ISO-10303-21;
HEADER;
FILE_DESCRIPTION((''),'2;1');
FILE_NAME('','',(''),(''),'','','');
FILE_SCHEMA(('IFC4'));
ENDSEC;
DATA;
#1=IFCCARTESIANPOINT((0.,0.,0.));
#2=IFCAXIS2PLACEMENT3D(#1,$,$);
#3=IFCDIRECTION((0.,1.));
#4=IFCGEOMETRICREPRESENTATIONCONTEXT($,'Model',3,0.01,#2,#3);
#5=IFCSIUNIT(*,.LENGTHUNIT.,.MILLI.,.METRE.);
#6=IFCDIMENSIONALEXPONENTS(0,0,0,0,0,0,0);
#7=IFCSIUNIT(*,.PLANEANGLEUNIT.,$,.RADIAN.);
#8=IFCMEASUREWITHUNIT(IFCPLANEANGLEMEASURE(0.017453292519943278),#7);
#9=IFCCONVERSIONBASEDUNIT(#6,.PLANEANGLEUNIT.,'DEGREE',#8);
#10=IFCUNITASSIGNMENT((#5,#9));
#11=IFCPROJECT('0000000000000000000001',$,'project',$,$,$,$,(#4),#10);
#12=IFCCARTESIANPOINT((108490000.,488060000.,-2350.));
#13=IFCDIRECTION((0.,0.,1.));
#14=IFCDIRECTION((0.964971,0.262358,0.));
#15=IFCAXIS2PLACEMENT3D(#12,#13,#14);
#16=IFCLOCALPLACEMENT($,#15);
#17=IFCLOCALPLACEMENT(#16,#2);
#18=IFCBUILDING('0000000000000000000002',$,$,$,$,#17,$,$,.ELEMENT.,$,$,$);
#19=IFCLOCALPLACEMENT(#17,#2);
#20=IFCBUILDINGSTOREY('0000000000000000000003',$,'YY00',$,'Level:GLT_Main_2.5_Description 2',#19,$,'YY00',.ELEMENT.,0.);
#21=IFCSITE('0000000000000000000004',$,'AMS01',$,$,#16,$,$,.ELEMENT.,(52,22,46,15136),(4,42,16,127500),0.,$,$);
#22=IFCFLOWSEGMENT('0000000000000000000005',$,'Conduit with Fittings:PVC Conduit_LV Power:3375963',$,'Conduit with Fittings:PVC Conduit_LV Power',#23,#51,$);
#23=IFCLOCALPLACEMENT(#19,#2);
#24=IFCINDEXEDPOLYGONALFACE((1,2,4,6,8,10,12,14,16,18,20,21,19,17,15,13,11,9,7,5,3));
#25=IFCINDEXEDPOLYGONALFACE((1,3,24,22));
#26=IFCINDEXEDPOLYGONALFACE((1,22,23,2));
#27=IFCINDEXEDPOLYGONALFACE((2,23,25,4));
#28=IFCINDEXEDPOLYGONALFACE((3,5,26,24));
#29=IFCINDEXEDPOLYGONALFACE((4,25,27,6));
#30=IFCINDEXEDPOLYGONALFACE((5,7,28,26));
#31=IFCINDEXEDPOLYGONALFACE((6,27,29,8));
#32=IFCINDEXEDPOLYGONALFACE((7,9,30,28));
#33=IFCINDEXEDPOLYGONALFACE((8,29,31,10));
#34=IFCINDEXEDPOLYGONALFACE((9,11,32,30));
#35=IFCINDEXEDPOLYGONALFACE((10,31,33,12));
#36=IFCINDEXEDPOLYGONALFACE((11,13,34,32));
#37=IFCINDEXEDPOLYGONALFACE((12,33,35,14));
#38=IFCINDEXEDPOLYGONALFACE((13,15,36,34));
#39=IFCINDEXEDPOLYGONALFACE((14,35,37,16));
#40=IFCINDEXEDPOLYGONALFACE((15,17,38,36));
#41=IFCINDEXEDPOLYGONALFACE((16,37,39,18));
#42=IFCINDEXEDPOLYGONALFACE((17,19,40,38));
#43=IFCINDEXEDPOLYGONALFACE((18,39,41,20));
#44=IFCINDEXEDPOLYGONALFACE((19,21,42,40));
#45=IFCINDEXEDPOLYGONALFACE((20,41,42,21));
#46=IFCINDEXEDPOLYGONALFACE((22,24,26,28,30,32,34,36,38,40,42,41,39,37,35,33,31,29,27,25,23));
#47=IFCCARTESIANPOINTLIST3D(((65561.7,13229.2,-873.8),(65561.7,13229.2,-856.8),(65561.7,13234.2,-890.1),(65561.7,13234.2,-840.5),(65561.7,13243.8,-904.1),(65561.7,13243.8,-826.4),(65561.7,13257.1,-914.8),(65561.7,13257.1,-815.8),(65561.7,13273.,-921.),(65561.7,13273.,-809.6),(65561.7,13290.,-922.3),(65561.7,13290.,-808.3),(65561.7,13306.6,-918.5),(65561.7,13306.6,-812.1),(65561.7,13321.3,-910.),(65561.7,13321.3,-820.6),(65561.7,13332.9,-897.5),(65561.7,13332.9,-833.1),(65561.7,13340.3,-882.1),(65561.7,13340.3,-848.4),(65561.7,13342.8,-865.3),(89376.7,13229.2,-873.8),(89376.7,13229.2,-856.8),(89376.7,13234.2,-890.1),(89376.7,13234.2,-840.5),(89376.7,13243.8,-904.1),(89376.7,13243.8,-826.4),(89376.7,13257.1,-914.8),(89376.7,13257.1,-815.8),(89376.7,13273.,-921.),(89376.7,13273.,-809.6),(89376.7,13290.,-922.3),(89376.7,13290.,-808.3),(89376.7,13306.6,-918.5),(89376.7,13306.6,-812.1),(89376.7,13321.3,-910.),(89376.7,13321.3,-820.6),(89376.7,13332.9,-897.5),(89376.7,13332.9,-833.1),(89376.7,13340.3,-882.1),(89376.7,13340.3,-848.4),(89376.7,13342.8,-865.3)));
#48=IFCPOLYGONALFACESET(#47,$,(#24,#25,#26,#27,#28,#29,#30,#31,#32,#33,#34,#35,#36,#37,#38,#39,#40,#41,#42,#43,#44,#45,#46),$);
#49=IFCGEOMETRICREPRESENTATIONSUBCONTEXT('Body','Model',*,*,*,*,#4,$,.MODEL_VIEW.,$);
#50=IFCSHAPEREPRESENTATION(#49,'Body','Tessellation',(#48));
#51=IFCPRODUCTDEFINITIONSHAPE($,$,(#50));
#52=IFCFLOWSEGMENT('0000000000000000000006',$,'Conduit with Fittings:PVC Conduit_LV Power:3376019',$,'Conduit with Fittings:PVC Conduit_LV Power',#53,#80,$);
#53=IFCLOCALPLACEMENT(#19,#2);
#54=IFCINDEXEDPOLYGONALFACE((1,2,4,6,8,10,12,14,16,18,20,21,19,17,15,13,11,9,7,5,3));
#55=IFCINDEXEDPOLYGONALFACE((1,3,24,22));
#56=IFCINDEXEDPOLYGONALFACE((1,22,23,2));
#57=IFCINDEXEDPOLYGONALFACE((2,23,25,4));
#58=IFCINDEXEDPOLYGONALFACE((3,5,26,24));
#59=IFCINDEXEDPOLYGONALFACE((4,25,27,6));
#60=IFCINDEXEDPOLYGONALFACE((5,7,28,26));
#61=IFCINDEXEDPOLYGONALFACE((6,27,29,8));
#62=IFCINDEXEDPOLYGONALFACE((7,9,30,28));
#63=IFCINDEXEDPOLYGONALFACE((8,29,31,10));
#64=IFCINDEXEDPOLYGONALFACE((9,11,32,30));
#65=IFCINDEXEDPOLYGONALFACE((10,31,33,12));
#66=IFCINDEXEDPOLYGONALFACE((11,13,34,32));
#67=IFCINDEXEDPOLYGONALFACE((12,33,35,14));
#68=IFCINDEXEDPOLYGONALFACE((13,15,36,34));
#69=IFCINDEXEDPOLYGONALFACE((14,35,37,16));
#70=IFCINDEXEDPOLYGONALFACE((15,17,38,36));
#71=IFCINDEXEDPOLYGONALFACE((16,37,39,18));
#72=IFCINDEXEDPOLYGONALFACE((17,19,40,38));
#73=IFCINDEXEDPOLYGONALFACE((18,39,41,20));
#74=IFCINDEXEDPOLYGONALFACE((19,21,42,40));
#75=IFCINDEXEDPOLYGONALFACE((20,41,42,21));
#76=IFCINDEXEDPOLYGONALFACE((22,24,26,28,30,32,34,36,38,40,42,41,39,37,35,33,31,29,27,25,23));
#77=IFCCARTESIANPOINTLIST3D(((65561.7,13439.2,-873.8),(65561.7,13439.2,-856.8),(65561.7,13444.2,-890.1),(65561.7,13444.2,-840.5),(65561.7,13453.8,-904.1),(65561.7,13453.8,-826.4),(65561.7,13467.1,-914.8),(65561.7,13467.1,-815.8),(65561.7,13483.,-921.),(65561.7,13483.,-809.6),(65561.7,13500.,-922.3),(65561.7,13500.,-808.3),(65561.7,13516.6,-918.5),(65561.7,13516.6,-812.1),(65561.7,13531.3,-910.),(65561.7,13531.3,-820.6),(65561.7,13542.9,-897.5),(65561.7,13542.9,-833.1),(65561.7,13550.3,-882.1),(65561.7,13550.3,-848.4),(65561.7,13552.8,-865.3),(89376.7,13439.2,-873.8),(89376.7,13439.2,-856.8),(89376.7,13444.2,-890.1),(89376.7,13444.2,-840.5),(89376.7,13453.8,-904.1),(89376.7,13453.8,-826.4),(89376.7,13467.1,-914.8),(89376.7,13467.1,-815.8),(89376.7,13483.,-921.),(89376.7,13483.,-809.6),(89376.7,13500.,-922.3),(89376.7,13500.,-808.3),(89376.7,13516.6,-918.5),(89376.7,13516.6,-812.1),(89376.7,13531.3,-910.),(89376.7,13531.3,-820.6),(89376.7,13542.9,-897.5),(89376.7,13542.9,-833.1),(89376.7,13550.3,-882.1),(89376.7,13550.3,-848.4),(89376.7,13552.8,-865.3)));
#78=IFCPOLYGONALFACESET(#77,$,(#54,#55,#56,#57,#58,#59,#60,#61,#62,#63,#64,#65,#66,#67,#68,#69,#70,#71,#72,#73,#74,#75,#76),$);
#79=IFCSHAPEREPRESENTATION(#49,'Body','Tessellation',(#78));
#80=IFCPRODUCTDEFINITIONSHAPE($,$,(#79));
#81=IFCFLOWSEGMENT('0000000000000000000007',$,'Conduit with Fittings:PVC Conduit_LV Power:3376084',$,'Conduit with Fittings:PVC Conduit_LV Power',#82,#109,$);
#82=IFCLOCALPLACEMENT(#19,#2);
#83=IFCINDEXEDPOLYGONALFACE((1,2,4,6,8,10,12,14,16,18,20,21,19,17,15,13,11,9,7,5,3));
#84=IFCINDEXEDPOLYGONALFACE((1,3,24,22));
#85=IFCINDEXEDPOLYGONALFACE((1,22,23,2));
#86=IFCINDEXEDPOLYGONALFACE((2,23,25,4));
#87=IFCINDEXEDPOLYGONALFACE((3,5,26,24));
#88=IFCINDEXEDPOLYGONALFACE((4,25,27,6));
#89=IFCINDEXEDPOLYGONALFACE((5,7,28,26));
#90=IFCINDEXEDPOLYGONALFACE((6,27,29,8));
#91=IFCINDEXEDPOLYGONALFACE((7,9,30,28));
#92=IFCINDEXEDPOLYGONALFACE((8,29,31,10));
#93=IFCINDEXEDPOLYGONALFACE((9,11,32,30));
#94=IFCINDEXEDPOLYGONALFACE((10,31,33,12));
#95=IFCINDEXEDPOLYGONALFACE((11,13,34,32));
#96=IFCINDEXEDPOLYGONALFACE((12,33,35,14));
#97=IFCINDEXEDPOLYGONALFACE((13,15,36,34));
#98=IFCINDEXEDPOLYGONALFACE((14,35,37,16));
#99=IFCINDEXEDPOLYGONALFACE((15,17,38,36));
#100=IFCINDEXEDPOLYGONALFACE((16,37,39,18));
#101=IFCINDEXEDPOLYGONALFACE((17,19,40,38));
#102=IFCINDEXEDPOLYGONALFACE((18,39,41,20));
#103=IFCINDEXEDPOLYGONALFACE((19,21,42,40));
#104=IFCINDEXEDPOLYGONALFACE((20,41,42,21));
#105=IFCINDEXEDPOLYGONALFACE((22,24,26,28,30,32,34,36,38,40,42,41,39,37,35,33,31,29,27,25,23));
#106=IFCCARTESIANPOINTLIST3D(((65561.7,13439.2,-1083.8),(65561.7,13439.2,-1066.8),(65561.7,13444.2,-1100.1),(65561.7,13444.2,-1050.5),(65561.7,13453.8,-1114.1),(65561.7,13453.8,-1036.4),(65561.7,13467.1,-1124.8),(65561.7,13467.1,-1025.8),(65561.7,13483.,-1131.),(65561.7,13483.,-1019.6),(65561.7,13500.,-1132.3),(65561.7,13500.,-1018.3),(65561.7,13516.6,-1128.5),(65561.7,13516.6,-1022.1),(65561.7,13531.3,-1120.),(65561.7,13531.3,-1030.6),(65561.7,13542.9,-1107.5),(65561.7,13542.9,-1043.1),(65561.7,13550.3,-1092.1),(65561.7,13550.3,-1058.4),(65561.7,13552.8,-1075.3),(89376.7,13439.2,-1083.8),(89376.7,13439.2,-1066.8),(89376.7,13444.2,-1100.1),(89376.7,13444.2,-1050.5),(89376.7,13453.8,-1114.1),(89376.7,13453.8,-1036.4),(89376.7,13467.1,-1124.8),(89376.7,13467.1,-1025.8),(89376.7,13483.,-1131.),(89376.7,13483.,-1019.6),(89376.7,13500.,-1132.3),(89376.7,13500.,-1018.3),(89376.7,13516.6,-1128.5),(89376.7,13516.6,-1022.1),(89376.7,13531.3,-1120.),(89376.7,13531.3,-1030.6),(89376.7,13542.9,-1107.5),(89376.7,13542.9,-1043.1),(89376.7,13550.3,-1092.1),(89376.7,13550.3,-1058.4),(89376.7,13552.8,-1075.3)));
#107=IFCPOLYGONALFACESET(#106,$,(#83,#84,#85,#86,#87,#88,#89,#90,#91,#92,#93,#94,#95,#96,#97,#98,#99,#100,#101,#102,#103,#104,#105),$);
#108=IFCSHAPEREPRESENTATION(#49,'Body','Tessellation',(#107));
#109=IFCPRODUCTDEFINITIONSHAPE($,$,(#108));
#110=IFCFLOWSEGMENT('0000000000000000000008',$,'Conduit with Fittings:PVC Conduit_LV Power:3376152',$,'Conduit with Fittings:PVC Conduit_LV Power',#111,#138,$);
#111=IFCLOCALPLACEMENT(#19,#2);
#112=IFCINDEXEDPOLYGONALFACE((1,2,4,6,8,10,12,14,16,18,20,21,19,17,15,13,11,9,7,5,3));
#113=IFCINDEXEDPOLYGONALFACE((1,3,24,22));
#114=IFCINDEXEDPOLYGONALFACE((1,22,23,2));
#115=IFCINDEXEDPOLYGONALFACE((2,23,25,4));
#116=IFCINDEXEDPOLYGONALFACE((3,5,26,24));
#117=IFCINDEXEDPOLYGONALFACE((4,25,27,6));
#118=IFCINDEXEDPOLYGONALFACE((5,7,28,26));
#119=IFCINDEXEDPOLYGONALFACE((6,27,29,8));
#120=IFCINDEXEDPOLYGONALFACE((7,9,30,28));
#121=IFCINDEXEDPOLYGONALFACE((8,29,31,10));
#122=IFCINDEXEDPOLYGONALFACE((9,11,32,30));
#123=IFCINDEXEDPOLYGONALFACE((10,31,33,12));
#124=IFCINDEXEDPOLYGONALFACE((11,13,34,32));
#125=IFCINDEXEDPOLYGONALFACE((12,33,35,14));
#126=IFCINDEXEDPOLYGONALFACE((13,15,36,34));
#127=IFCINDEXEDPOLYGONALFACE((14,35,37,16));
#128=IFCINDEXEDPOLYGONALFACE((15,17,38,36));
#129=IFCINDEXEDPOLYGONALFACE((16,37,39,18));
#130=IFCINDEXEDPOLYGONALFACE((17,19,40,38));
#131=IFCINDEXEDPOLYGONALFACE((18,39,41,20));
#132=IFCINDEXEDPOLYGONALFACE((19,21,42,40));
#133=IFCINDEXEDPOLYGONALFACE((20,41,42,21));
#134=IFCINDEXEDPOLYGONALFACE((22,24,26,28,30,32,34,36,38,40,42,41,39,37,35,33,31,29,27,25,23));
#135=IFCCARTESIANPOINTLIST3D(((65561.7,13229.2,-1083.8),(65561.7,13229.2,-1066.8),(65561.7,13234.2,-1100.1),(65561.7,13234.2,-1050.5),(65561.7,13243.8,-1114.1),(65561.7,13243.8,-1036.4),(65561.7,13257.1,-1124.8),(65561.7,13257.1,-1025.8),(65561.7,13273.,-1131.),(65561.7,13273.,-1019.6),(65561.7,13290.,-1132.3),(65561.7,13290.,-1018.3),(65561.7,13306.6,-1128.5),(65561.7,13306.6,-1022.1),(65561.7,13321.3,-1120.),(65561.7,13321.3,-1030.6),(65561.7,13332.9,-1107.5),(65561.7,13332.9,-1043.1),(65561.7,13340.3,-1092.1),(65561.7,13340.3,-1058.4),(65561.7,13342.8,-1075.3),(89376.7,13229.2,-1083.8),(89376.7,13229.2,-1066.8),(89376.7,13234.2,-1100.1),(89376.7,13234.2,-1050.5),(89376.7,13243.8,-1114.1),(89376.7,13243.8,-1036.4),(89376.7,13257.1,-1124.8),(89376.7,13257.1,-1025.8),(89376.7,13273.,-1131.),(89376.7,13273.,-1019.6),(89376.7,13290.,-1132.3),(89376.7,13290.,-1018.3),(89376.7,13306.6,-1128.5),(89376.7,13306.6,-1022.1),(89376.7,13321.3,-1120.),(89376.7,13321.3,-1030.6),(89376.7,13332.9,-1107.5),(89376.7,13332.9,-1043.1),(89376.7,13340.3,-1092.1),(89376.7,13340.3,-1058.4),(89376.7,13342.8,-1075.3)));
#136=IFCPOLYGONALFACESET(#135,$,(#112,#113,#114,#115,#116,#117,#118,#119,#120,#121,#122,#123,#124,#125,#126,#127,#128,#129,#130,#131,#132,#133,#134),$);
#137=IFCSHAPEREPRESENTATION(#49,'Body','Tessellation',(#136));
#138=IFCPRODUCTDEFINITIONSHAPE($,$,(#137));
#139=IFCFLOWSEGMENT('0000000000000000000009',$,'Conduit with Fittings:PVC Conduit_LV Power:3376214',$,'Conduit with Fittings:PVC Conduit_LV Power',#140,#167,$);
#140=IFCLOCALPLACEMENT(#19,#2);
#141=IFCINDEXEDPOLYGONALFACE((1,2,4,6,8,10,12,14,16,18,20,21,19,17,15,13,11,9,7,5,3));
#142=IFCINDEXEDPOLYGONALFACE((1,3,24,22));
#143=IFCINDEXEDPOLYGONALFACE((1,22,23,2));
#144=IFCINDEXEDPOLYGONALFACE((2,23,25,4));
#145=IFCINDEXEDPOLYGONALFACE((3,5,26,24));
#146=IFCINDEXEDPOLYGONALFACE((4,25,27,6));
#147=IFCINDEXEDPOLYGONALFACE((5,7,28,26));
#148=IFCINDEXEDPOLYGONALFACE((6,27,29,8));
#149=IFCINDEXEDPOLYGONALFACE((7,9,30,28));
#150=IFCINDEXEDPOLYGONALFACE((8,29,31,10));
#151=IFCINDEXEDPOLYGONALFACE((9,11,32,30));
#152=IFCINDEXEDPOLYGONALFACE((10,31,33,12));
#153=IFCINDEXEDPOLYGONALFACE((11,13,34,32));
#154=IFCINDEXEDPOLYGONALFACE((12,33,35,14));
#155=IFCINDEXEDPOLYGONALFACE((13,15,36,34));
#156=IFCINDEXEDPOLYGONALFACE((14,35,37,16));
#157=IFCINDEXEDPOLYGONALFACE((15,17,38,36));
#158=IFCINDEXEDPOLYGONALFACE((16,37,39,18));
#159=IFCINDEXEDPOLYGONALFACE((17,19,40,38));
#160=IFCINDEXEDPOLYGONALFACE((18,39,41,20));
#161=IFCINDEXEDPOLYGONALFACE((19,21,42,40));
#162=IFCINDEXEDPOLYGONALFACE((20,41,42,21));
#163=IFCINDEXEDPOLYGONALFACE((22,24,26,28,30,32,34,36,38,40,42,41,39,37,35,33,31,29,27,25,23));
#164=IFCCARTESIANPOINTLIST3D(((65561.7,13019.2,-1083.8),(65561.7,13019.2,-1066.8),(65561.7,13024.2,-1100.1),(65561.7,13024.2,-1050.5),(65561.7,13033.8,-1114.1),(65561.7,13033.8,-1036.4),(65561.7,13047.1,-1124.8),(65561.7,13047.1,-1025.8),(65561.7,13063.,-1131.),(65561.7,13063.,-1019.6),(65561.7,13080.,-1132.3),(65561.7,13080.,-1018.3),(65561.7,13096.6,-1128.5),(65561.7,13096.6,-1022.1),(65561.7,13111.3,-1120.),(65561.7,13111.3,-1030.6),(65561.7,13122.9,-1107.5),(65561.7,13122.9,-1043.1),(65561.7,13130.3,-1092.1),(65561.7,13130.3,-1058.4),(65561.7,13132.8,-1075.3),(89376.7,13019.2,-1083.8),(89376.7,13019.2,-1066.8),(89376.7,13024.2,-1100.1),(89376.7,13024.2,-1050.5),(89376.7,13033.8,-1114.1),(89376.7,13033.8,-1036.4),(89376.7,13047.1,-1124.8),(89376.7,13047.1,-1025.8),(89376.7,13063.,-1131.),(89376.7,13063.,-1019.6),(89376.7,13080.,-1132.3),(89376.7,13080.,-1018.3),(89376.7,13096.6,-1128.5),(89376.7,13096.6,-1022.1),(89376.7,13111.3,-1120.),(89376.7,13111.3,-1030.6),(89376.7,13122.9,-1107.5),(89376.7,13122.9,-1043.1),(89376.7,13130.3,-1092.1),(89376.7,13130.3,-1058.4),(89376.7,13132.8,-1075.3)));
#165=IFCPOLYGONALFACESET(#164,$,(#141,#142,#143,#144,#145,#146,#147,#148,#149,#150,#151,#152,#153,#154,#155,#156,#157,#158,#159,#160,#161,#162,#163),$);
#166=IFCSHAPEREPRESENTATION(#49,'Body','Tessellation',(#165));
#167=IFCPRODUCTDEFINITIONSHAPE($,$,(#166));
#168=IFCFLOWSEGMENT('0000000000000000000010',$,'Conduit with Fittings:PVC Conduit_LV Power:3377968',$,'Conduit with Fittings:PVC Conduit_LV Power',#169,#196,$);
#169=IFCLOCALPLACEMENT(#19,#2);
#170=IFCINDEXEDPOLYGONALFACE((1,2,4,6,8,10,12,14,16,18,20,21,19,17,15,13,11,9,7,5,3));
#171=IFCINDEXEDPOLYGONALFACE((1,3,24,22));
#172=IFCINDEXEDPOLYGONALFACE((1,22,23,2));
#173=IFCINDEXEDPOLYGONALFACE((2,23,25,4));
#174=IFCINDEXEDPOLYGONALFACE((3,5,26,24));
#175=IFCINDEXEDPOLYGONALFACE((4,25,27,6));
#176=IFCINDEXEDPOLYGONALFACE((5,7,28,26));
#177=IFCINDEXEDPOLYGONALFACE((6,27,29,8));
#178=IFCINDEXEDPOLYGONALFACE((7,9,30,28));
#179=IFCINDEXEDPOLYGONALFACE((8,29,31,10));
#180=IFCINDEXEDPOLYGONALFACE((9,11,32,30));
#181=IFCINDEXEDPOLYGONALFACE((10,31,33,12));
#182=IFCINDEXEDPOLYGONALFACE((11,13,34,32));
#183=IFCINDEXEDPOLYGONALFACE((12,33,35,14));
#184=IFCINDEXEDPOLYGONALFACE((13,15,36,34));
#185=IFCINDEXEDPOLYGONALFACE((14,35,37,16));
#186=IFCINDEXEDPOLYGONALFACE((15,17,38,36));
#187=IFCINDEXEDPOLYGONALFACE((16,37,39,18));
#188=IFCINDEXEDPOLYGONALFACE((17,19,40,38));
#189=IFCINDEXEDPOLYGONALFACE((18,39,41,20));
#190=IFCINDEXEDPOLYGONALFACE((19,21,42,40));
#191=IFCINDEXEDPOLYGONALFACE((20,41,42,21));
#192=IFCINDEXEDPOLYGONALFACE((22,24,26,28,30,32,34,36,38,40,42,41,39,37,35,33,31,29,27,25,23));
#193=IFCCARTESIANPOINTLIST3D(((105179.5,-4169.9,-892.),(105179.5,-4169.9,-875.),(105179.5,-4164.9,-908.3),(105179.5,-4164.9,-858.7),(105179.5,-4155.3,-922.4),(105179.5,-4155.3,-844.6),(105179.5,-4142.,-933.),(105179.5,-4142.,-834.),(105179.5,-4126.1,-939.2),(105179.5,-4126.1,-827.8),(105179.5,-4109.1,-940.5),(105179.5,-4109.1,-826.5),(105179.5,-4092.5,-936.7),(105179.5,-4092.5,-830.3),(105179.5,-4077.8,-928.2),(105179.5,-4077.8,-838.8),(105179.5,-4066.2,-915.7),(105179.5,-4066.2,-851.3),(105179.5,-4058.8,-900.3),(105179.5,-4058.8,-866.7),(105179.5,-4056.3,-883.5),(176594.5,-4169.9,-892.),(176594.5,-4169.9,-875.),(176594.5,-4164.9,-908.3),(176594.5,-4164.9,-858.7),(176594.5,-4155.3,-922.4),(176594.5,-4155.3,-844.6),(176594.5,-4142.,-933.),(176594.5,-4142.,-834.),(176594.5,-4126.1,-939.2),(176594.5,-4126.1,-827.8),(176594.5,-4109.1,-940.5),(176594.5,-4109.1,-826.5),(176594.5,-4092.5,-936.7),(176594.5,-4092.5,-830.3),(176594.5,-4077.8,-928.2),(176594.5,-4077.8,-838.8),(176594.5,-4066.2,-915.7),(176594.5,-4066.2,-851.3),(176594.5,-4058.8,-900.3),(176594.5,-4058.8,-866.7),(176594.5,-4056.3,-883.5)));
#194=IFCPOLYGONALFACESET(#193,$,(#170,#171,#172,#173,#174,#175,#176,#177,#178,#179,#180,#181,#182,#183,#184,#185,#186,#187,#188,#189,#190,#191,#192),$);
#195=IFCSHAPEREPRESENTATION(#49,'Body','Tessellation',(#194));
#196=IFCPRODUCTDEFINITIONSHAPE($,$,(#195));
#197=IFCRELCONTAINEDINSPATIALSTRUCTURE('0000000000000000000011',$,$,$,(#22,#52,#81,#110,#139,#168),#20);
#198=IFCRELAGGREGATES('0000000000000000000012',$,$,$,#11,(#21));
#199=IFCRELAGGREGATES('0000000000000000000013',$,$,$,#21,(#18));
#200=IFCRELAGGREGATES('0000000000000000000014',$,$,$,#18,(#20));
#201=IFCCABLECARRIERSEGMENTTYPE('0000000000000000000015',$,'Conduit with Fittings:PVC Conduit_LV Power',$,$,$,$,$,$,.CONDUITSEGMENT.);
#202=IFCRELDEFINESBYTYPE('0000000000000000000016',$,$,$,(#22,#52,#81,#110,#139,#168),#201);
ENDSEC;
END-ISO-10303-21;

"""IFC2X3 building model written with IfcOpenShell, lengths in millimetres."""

from ifc_helpers import new_model, entity, si_unit, converted_unit, direction, frame, frame_2d, origin, place, context, subcontext, project, spatial, circle, extrude, type_object, element, save


model = new_model("IFC2X3")

# Units and contexts
model_context = context("Model", 3, precision=0.01, world=origin(), true_north=direction((0.0, 1.0)))
body_context = subcontext(model_context, "Body", "Model", "MODEL_VIEW")
ifc_project = project(units=[si_unit("LENGTHUNIT", "METRE", prefix="MILLI"), converted_unit("PLANEANGLEUNIT", "DEGREE", entity("IfcPlaneAngleMeasure", 0.017453292519943278), si_unit("PLANEANGLEUNIT", "RADIAN"), dimensions=[0, 0, 0, 0, 0, 0, 0])], contexts=[model_context])

# Site, building, storey
site_placement = place(None, frame((108490000.0, 488060000.0, -2350.0), z_axis=(0.0, 0.0, 1.0), x_axis=(0.964971, 0.262358, 0.0)))
site = spatial("IfcSite", under=ifc_project, at=site_placement, Name="AMS01", CompositionType="ELEMENT", RefLatitude=(52, 22, 46, 15136), RefLongitude=(4, 42, 16, 127500), RefElevation=0.0)
building_placement = place(site_placement, origin())
building = spatial("IfcBuilding", under=site, at=building_placement, CompositionType="ELEMENT")
storey_placement = place(building_placement, origin())
storey = spatial("IfcBuildingStorey", under=building, at=storey_placement, Name="YY00", ObjectType="Level:GLT_Main_2.5_Description 2", LongName="YY00", CompositionType="ELEMENT", Elevation=0.0)

# Flow segments
cable_carrier_segment_type = type_object("IfcCableCarrierSegmentType", Name="Conduit with Fittings:PVC Conduit_LV Power", PredefinedType="CONDUITSEGMENT")
flow_segment_1_placement = place(storey_placement, origin())
element("IfcFlowSegment", 1, at=flow_segment_1_placement, inside=storey, type_object=cable_carrier_segment_type, Name="Conduit with Fittings:PVC Conduit_LV Power:3375963", ObjectType="Conduit with Fittings:PVC Conduit_LV Power", context=body_context, shape_type="SweptSolid", body=[
    extrude(circle(Radius=57.2, at=frame_2d((0.0, 0.0), x_axis=(1.0, 0.0))), frame((65561.7, 13285.7, -865.3), z_axis=(1.0, 0.0, 0.0), x_axis=(0.0, 1.0, 0.0)), (0.0, 0.0, 1.0), 23815.0),
])
flow_segment_2_placement = place(storey_placement, origin())
element("IfcFlowSegment", 2, at=flow_segment_2_placement, inside=storey, type_object=cable_carrier_segment_type, Name="Conduit with Fittings:PVC Conduit_LV Power:3376019", ObjectType="Conduit with Fittings:PVC Conduit_LV Power", context=body_context, shape_type="SweptSolid", body=[
    extrude(circle(Radius=57.2, at=frame_2d((0.0, 0.0), x_axis=(1.0, 0.0))), frame((65561.7, 13495.7, -865.3), z_axis=(1.0, 0.0, 0.0), x_axis=(0.0, 1.0, 0.0)), (0.0, 0.0, 1.0), 23815.0),
])
flow_segment_3_placement = place(storey_placement, origin())
element("IfcFlowSegment", 3, at=flow_segment_3_placement, inside=storey, type_object=cable_carrier_segment_type, Name="Conduit with Fittings:PVC Conduit_LV Power:3376084", ObjectType="Conduit with Fittings:PVC Conduit_LV Power", context=body_context, shape_type="SweptSolid", body=[
    extrude(circle(Radius=57.2, at=frame_2d((0.0, 0.0), x_axis=(1.0, 0.0))), frame((65561.7, 13495.7, -1075.3), z_axis=(1.0, 0.0, 0.0), x_axis=(0.0, 1.0, 0.0)), (0.0, 0.0, 1.0), 23815.0),
])
flow_segment_4_placement = place(storey_placement, origin())
element("IfcFlowSegment", 4, at=flow_segment_4_placement, inside=storey, type_object=cable_carrier_segment_type, Name="Conduit with Fittings:PVC Conduit_LV Power:3376152", ObjectType="Conduit with Fittings:PVC Conduit_LV Power", context=body_context, shape_type="SweptSolid", body=[
    extrude(circle(Radius=57.2, at=frame_2d((0.0, 0.0), x_axis=(1.0, 0.0))), frame((65561.7, 13285.7, -1075.3), z_axis=(1.0, 0.0, 0.0), x_axis=(0.0, 1.0, 0.0)), (0.0, 0.0, 1.0), 23815.0),
])
flow_segment_5_placement = place(storey_placement, origin())
element("IfcFlowSegment", 5, at=flow_segment_5_placement, inside=storey, type_object=cable_carrier_segment_type, Name="Conduit with Fittings:PVC Conduit_LV Power:3376214", ObjectType="Conduit with Fittings:PVC Conduit_LV Power", context=body_context, shape_type="SweptSolid", body=[
    extrude(circle(Radius=57.2, at=frame_2d((0.0, 0.0), x_axis=(1.0, 0.0))), frame((65561.7, 13075.7, -1075.3), z_axis=(1.0, 0.0, 0.0), x_axis=(0.0, 1.0, 0.0)), (0.0, 0.0, 1.0), 23815.0),
])
flow_segment_6_placement = place(storey_placement, origin())
element("IfcFlowSegment", 6, at=flow_segment_6_placement, inside=storey, type_object=cable_carrier_segment_type, Name="Conduit with Fittings:PVC Conduit_LV Power:3377968", ObjectType="Conduit with Fittings:PVC Conduit_LV Power", context=body_context, shape_type="SweptSolid", body=[
    extrude(circle(Radius=57.2, at=frame_2d((0.0, 0.0), x_axis=(1.0, 0.0))), frame((105179.5, -4113.4, -883.5), z_axis=(1.0, 0.0, 0.0), x_axis=(0.0, 1.0, 0.0)), (0.0, 0.0, 1.0), 71415.0),
])

save(model, "model.ifc")
